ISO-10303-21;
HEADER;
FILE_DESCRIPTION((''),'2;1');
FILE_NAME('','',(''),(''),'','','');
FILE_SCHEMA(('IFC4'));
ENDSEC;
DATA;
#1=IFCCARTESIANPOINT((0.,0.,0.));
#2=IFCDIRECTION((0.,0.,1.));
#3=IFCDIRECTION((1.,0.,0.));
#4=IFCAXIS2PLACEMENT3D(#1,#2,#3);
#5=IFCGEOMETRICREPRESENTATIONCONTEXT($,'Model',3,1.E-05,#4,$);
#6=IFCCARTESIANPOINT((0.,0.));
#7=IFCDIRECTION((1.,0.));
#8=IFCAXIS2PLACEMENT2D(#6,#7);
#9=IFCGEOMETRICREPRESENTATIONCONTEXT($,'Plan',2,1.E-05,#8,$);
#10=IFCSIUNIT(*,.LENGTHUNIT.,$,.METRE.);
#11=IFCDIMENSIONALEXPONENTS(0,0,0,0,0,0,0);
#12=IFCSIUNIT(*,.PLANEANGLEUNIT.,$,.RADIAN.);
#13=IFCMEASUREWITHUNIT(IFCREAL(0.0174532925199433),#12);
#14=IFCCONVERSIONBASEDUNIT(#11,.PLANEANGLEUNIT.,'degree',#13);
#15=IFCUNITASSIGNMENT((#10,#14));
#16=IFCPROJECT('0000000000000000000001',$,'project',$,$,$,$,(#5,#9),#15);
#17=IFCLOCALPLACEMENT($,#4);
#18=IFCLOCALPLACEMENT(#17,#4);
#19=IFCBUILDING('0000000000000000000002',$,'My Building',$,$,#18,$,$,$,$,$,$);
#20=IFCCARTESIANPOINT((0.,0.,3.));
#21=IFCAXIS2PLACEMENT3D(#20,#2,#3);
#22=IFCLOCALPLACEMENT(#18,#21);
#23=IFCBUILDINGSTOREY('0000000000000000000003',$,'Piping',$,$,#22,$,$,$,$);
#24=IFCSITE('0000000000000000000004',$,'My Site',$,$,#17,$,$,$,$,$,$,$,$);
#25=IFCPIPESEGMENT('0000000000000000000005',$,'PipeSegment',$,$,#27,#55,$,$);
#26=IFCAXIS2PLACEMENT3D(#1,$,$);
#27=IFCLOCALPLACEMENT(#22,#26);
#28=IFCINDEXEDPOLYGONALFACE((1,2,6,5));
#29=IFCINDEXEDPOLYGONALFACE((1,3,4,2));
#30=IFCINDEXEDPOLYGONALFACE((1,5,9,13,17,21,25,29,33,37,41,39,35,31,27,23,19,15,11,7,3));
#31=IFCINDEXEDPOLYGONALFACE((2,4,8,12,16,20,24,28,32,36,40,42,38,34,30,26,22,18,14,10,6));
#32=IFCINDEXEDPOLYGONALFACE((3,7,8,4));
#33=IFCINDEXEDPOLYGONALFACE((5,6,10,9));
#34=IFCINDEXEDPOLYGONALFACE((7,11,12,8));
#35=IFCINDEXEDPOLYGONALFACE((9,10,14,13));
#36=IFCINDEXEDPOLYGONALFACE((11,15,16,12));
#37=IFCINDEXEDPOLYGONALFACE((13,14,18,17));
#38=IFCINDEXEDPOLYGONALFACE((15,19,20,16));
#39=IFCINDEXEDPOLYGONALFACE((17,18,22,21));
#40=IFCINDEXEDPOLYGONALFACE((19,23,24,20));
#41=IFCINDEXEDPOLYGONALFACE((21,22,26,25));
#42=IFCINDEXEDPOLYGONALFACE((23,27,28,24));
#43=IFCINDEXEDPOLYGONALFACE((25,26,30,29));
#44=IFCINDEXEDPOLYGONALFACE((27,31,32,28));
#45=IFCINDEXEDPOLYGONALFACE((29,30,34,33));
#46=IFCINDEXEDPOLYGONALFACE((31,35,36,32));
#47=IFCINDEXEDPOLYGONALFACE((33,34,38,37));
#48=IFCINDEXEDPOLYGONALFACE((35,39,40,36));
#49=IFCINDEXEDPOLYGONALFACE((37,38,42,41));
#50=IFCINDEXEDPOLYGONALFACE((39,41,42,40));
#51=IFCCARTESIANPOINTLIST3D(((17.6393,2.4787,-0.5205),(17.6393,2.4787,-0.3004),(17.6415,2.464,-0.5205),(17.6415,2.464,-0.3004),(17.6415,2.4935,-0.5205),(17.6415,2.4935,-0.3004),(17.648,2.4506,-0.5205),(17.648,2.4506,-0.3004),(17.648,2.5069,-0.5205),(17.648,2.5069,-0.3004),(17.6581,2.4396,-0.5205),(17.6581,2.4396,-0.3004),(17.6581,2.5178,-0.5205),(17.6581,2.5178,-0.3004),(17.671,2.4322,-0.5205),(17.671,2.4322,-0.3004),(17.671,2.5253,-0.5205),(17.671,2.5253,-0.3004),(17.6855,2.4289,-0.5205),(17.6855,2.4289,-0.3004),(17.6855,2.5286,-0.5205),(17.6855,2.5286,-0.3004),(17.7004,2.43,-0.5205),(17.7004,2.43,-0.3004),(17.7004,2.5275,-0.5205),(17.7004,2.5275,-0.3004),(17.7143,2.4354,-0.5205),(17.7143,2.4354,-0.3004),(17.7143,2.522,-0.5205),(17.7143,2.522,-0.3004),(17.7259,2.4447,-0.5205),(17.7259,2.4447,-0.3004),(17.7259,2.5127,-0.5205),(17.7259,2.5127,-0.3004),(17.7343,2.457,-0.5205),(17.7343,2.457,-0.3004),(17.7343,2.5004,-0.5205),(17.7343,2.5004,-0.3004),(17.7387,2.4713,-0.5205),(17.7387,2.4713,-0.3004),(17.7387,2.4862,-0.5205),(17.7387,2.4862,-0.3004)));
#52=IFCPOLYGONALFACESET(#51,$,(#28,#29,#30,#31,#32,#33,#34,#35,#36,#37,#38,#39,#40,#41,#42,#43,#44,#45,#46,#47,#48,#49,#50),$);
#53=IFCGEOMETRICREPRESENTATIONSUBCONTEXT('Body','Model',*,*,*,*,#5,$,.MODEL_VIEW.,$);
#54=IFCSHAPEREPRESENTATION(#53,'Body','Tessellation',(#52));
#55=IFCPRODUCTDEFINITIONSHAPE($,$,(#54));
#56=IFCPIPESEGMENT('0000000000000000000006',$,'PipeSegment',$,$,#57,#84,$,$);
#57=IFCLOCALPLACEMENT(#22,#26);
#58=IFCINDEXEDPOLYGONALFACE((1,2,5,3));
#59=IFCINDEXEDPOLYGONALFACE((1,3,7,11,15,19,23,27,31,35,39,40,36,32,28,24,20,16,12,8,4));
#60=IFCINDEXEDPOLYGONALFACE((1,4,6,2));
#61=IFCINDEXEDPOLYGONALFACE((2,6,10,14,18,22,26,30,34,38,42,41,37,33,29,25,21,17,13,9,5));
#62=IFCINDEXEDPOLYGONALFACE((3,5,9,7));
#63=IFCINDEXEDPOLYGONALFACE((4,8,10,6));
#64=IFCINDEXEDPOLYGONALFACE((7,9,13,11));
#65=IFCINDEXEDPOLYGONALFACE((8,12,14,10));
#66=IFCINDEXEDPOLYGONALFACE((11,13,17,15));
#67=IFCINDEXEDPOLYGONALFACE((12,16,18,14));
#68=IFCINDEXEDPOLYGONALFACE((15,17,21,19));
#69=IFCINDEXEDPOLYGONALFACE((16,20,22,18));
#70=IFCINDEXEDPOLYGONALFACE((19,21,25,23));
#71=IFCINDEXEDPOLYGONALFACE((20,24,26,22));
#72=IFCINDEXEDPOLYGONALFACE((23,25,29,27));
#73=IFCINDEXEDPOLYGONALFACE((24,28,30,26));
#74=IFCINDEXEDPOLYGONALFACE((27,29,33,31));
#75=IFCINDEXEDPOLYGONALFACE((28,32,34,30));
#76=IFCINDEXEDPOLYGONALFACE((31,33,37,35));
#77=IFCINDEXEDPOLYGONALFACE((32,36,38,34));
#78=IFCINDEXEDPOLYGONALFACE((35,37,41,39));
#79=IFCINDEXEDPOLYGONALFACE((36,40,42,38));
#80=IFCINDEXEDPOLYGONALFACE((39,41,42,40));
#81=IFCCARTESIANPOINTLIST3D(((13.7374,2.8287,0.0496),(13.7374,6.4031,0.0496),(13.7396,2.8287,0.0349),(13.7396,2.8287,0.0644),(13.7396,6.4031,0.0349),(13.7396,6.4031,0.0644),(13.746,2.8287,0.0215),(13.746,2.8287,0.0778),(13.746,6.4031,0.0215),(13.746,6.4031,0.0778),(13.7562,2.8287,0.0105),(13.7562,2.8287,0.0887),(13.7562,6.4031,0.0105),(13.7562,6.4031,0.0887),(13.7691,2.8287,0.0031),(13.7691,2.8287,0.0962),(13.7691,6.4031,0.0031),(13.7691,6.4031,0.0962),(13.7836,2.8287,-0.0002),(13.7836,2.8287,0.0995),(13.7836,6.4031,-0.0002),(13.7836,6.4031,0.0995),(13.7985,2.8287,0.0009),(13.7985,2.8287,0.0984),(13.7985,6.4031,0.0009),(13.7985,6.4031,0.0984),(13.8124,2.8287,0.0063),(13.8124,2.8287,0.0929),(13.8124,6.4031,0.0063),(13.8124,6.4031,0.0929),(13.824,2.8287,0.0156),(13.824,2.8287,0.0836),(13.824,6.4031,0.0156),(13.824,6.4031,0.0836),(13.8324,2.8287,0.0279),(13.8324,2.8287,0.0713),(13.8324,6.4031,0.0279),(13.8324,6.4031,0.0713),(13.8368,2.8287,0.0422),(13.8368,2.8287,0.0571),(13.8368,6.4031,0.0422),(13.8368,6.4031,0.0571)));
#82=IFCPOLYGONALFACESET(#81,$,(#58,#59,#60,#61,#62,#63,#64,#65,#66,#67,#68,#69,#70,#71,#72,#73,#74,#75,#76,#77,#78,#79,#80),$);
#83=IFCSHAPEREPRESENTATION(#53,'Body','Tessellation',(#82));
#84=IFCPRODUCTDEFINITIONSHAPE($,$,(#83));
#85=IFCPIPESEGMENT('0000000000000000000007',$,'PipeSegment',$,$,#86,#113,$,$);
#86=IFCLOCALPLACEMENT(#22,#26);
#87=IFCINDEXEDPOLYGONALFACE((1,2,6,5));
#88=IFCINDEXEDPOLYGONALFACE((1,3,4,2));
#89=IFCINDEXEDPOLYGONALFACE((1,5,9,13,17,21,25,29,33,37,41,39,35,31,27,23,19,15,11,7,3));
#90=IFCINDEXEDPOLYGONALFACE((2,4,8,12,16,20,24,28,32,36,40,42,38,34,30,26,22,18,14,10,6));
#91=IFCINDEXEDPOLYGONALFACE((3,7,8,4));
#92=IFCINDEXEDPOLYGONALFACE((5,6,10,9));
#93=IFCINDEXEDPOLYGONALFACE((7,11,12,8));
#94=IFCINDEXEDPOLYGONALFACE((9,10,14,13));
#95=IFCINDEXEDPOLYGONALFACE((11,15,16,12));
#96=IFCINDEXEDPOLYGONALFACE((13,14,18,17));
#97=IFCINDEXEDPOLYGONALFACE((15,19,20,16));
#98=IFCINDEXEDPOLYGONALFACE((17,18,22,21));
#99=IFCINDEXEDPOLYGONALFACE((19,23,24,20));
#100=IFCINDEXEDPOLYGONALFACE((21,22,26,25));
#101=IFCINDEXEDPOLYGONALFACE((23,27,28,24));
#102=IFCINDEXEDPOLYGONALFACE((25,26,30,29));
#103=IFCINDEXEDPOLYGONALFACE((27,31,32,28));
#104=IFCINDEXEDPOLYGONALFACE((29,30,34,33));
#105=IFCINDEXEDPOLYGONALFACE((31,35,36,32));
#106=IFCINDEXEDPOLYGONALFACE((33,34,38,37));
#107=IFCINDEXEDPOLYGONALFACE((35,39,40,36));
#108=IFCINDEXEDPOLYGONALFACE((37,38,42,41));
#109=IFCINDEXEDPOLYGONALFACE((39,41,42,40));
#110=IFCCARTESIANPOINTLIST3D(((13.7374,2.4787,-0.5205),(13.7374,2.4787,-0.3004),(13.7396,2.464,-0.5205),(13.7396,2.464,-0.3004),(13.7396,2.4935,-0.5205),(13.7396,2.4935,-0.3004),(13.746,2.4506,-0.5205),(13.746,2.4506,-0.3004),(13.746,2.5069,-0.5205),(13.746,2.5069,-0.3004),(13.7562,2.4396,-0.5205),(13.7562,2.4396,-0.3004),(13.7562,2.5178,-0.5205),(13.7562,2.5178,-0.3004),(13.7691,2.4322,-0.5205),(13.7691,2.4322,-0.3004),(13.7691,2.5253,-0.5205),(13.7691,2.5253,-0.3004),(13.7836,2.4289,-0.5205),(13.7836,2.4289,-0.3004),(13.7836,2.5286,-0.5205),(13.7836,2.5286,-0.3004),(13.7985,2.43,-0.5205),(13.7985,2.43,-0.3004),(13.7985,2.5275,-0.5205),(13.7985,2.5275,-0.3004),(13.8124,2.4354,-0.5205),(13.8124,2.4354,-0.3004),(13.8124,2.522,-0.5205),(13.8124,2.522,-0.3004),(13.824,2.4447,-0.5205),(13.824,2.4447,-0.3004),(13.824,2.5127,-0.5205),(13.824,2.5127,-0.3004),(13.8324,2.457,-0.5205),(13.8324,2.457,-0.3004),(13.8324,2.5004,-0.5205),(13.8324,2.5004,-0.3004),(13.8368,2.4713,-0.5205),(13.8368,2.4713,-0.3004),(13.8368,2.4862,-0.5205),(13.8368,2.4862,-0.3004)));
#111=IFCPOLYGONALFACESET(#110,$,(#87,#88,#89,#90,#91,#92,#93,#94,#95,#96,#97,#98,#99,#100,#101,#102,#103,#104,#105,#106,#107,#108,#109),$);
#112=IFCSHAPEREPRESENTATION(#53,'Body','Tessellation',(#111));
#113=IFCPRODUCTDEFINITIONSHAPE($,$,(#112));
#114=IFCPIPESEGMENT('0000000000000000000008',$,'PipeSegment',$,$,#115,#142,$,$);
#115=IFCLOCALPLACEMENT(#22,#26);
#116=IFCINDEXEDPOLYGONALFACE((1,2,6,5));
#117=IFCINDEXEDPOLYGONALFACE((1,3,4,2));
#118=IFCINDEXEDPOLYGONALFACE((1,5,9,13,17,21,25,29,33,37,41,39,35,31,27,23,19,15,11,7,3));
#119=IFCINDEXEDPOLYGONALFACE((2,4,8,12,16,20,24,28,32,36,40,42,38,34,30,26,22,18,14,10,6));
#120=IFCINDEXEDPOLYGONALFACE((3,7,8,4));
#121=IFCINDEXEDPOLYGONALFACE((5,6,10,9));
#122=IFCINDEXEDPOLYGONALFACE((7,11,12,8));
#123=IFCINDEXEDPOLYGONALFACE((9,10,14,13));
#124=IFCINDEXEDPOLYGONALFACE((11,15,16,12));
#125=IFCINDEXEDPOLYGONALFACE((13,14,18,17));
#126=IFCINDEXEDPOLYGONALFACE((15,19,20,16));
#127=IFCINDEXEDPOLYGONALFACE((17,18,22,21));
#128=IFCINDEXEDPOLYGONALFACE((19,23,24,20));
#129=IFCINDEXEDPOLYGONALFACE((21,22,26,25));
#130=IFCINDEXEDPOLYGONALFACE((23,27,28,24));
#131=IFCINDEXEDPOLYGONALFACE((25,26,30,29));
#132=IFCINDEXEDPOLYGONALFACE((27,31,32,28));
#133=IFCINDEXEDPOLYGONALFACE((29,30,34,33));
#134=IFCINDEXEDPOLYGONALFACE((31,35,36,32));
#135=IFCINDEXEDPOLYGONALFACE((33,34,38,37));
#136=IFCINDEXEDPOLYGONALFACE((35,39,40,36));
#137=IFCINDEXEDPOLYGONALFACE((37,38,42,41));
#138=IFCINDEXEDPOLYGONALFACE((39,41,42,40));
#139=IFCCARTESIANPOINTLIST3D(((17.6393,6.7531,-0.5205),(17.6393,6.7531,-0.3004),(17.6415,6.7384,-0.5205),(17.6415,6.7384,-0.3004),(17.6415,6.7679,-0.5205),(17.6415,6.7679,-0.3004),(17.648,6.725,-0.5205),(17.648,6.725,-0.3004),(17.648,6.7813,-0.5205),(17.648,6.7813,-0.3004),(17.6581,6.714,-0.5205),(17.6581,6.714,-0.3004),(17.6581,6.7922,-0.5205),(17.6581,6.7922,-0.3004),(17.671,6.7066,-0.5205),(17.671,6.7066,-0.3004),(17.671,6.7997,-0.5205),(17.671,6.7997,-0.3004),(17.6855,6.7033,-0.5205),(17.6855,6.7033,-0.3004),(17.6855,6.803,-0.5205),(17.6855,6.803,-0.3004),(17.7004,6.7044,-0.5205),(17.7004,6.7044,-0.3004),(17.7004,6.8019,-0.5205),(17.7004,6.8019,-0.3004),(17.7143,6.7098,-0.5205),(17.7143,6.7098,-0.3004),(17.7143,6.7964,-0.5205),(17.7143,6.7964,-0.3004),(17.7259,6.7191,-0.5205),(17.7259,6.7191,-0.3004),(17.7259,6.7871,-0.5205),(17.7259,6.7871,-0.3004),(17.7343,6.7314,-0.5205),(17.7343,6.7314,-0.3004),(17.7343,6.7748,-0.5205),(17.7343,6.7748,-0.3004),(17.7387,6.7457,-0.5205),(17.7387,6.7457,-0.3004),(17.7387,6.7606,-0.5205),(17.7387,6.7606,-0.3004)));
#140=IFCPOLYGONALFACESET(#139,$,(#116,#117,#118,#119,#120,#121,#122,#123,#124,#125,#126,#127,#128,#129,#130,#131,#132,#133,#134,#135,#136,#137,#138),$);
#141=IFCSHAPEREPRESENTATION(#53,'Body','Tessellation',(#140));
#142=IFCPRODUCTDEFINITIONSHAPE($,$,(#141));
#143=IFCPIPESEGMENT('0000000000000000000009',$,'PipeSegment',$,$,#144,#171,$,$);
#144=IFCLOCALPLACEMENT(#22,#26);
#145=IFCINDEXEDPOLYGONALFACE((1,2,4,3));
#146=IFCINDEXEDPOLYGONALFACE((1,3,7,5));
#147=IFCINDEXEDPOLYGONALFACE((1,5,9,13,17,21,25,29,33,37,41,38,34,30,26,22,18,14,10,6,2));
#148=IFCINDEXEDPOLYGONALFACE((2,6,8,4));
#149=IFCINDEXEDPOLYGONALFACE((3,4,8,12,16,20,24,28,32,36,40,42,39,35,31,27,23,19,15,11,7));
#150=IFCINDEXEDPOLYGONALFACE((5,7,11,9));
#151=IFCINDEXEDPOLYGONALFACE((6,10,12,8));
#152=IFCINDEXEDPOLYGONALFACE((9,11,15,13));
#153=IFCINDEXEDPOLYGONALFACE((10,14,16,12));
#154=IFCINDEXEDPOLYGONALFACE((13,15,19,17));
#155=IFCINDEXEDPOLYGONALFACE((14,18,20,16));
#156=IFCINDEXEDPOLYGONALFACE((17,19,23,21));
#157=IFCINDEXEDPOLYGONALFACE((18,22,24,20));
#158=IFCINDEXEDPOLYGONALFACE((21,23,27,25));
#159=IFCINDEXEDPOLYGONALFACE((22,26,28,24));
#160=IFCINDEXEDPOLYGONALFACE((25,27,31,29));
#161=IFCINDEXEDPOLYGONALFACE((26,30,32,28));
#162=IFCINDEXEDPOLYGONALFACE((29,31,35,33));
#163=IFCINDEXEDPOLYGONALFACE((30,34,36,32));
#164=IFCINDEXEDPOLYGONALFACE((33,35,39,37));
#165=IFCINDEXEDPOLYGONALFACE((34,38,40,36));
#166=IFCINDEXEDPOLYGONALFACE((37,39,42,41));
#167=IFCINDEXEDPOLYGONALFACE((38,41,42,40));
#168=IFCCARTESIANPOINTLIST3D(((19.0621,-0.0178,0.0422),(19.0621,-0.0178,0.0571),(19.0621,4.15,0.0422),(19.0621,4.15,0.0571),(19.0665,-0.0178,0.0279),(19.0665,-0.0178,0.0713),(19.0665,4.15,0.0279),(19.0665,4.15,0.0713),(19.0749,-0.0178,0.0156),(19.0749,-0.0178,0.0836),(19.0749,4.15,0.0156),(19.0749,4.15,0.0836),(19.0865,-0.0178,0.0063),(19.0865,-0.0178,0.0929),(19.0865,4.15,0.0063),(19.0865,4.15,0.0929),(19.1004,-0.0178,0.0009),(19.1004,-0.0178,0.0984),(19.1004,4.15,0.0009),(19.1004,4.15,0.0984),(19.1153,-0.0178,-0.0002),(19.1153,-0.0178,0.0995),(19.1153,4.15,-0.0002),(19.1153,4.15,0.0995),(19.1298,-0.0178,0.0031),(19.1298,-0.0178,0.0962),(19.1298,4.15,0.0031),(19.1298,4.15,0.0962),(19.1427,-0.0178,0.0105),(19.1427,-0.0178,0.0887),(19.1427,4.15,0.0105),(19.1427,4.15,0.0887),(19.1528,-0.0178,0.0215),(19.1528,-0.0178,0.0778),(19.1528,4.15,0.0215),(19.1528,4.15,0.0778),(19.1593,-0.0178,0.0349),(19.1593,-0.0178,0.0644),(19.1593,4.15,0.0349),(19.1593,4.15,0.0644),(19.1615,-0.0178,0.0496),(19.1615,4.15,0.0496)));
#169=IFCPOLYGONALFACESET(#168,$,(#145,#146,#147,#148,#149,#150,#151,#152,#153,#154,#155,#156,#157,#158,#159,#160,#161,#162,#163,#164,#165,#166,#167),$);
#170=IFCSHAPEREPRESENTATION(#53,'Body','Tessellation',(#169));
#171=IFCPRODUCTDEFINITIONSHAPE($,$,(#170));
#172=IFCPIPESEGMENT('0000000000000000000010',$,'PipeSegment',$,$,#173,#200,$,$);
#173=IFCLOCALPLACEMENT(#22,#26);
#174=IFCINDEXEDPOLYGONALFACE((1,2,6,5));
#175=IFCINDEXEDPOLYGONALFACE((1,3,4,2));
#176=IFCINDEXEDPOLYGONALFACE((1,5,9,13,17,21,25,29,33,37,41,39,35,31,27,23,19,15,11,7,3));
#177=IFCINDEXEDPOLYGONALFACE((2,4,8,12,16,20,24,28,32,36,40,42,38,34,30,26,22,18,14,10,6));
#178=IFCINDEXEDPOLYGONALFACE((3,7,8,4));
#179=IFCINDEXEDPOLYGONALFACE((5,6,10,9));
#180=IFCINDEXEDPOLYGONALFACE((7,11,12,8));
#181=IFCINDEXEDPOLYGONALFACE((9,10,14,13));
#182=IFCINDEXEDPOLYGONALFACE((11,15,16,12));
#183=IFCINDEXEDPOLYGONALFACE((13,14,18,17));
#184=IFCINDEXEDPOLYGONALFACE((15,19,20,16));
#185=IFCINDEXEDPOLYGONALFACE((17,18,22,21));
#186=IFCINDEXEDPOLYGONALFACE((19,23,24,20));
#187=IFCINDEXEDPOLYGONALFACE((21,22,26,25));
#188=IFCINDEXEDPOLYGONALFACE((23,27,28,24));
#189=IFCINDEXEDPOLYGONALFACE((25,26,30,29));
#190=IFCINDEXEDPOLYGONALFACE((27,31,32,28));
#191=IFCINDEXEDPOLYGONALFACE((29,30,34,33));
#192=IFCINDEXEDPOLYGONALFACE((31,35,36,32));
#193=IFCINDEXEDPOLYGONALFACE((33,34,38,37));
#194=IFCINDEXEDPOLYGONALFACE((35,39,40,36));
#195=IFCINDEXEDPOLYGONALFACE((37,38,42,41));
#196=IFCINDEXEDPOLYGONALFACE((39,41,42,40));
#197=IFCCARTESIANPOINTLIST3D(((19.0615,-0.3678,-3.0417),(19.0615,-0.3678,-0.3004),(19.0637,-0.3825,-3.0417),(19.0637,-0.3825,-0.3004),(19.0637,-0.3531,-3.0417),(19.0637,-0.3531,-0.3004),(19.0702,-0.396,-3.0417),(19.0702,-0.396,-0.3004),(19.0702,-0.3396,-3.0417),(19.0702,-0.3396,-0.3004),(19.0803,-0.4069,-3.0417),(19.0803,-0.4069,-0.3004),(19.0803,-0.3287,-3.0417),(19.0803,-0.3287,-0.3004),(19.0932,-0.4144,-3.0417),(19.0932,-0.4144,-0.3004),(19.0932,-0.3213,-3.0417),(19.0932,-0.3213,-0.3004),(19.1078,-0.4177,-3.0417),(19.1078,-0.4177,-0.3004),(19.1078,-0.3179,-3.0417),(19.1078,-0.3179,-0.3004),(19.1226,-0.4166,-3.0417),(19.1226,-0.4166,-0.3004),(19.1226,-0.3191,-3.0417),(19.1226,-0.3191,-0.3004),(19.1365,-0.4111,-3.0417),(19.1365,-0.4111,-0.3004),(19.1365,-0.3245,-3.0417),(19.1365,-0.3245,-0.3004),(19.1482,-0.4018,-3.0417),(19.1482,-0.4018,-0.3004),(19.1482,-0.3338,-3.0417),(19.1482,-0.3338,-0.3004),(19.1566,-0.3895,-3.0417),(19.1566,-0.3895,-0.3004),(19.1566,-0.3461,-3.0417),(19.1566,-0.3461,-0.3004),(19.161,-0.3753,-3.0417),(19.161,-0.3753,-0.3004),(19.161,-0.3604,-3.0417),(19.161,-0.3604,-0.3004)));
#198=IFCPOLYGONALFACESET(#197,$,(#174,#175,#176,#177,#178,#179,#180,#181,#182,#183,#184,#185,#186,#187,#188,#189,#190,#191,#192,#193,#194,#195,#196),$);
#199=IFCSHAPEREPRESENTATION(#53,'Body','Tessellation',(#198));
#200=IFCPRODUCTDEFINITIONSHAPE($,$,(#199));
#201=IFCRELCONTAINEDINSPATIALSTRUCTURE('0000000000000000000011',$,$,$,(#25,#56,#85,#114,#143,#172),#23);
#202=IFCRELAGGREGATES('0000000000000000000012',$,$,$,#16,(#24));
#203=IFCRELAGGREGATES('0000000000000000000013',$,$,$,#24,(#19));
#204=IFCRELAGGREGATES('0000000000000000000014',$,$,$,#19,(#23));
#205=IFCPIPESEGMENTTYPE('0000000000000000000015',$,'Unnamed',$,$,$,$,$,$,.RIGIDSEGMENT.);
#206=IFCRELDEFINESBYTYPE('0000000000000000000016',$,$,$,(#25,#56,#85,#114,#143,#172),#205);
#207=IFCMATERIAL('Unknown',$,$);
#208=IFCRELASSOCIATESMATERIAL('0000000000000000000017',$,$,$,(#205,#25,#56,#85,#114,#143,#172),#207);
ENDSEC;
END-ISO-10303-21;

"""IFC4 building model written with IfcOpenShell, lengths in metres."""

from ifc_helpers import new_model, entity, si_unit, converted_unit, frame, origin_with_axes, origin_2d_with_axis, place, context, subcontext, project, spatial, circle, extrude, material, material_profile, profile_set, profile_usage, type_object, element, save


model = new_model("IFC4")

# Units and contexts
model_context = context("Model", 3, precision=1e-05, world=origin_with_axes())
plan_context = context("Plan", 2, precision=1e-05, world=origin_2d_with_axis())
body_context = subcontext(model_context, "Body", "Model", "MODEL_VIEW")
ifc_project = project(units=[si_unit("LENGTHUNIT", "METRE"), converted_unit("PLANEANGLEUNIT", "degree", entity("IfcReal", 0.0174532925199433), si_unit("PLANEANGLEUNIT", "RADIAN"), dimensions=[0, 0, 0, 0, 0, 0, 0])], contexts=[model_context, plan_context])

# Site, building, storey
site_placement = place(None, origin_with_axes())
site = spatial("IfcSite", under=ifc_project, at=site_placement, Name="My Site")
building_placement = place(site_placement, origin_with_axes())
building = spatial("IfcBuilding", under=site, at=building_placement, Name="My Building")
storey_placement = place(building_placement, frame((0.0, 0.0, 3.0), z_axis=(0.0, 0.0, 1.0), x_axis=(1.0, 0.0, 0.0)))
storey = spatial("IfcBuildingStorey", under=building, at=storey_placement, Name="Piping")

# Pipe segments
ifc_material = material(Name="Unknown")
ifc_material_profile = material_profile(ifc_material, circle(Radius=0.05))
ifc_profile_set = profile_set([ifc_material_profile])
pipe_segment_type = type_object("IfcPipeSegmentType", Name="Unnamed", PredefinedType="RIGIDSEGMENT", material=ifc_profile_set)
ifc_profile_usage_1 = profile_usage(ifc_profile_set, cardinal=5)
pipe_segment_1_placement = place(storey_placement, frame((17.6893, 2.4787, -0.3004), z_axis=(0.0, 0.0, -1.0), x_axis=(-1.0, 0.0, 0.0)))
element("IfcPipeSegment", 1, at=pipe_segment_1_placement, inside=storey, type_object=pipe_segment_type, material=ifc_profile_usage_1, Name="PipeSegment", context=body_context, shape_type="SweptSolid", body=[
    extrude(circle(Radius=0.05), origin_with_axes(), (0.0, 0.0, 1.0), 0.2201),
])
ifc_profile_usage_2 = profile_usage(ifc_profile_set, cardinal=5)
pipe_segment_2_placement = place(storey_placement, frame((13.7874, 2.8287, 0.0496), z_axis=(0.0, 1.0, 0.0), x_axis=(-1.0, 0.0, 0.0)))
element("IfcPipeSegment", 2, at=pipe_segment_2_placement, inside=storey, type_object=pipe_segment_type, material=ifc_profile_usage_2, Name="PipeSegment", context=body_context, shape_type="SweptSolid", body=[
    extrude(circle(Radius=0.05), origin_with_axes(), (0.0, 0.0, 1.0), 3.5744),
])
ifc_profile_usage_3 = profile_usage(ifc_profile_set, cardinal=5)
pipe_segment_3_placement = place(storey_placement, frame((13.7874, 2.4787, -0.3004), z_axis=(0.0, 0.0, -1.0), x_axis=(-1.0, 0.0, 0.0)))
element("IfcPipeSegment", 3, at=pipe_segment_3_placement, inside=storey, type_object=pipe_segment_type, material=ifc_profile_usage_3, Name="PipeSegment", context=body_context, shape_type="SweptSolid", body=[
    extrude(circle(Radius=0.05), origin_with_axes(), (0.0, 0.0, 1.0), 0.2201),
])
ifc_profile_usage_4 = profile_usage(ifc_profile_set, cardinal=5)
pipe_segment_4_placement = place(storey_placement, frame((17.6893, 6.7531, -0.3004), z_axis=(0.0, 0.0, -1.0), x_axis=(-1.0, 0.0, 0.0)))
element("IfcPipeSegment", 4, at=pipe_segment_4_placement, inside=storey, type_object=pipe_segment_type, material=ifc_profile_usage_4, Name="PipeSegment", context=body_context, shape_type="SweptSolid", body=[
    extrude(circle(Radius=0.05), origin_with_axes(), (0.0, 0.0, 1.0), 0.2201),
])
ifc_profile_usage_5 = profile_usage(ifc_profile_set, cardinal=5)
pipe_segment_5_placement = place(storey_placement, frame((19.1115, 4.15, 0.0496), z_axis=(0.0, -1.0, 0.0), x_axis=(1.0, 0.0, 0.0)))
element("IfcPipeSegment", 5, at=pipe_segment_5_placement, inside=storey, type_object=pipe_segment_type, material=ifc_profile_usage_5, Name="PipeSegment", context=body_context, shape_type="SweptSolid", body=[
    extrude(circle(Radius=0.05), origin_with_axes(), (0.0, 0.0, 1.0), 4.1678),
])
ifc_profile_usage_6 = profile_usage(ifc_profile_set, cardinal=5)
pipe_segment_6_placement = place(storey_placement, frame((19.1115, -0.3678, -0.3004), z_axis=(0.0, 0.0, -1.0), x_axis=(-1.0, 0.0, 0.0)))
element("IfcPipeSegment", 6, at=pipe_segment_6_placement, inside=storey, type_object=pipe_segment_type, material=ifc_profile_usage_6, Name="PipeSegment", context=body_context, shape_type="SweptSolid", body=[
    extrude(circle(Radius=0.05), origin_with_axes(), (0.0, 0.0, 1.0), 2.7413),
])

save(model, "model.ifc")
